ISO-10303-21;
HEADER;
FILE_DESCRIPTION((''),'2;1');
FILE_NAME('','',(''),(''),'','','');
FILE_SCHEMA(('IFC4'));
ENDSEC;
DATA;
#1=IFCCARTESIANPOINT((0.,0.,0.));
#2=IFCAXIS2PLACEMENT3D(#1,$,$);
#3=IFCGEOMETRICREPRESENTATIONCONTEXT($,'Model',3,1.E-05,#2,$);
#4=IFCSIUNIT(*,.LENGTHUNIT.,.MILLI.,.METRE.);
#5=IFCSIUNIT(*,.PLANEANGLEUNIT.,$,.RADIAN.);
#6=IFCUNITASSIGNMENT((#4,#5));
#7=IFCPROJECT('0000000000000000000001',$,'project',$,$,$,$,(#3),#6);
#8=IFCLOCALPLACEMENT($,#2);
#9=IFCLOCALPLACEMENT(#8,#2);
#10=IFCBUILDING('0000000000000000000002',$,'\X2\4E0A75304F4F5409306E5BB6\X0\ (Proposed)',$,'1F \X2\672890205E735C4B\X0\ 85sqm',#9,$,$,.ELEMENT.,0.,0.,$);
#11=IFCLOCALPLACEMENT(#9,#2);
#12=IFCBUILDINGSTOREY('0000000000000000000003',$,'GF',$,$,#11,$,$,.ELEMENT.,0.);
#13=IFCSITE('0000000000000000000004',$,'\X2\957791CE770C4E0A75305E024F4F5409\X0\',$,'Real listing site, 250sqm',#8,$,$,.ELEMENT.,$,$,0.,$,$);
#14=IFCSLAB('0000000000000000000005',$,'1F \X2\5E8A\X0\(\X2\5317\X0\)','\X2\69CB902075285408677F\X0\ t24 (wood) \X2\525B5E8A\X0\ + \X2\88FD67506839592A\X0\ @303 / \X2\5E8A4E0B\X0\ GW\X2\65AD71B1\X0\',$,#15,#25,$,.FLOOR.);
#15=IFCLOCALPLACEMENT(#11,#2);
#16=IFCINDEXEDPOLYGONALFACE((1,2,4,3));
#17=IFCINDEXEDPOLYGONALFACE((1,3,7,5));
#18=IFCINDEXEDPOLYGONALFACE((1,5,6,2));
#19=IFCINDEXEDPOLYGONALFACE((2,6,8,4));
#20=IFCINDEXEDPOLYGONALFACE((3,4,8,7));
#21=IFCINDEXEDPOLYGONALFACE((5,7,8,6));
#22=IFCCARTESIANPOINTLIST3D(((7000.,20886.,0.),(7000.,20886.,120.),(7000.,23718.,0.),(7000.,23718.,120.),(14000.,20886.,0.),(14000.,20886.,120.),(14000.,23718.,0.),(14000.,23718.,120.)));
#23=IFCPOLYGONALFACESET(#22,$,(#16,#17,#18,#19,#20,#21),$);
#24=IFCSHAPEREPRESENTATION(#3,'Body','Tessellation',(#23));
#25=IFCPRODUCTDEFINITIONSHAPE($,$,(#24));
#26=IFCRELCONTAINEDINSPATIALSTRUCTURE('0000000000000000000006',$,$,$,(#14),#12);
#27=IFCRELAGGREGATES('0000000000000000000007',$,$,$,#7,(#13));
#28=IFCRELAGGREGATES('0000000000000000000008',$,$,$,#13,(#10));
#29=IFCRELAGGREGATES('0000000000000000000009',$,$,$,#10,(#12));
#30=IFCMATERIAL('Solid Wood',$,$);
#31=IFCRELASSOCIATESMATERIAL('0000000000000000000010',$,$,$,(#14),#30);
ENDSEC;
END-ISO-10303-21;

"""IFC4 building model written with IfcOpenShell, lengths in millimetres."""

from ifc_helpers import new_model, si_unit, frame, frame_2d, origin, place, context, project, spatial, rectangle, extrude, material, element, save


model = new_model("IFC4")

# Units and contexts
model_context = context("Model", 3, precision=1e-05, world=origin())
ifc_project = project(units=[si_unit("LENGTHUNIT", "METRE", prefix="MILLI"), si_unit("PLANEANGLEUNIT", "RADIAN")], contexts=[model_context])

# Site, building, storey
site_placement = place(None, origin())
site = spatial("IfcSite", under=ifc_project, at=site_placement, Name="長野県上田市住吉", ObjectType="Real listing site, 250sqm", CompositionType="ELEMENT", RefElevation=0.0)
building_placement = place(site_placement, origin())
building = spatial("IfcBuilding", under=site, at=building_placement, Name="上田住吉の家 (Proposed)", ObjectType="1F 木造平屋 85sqm", CompositionType="ELEMENT", ElevationOfRefHeight=0.0, ElevationOfTerrain=0.0)
storey_placement = place(building_placement, origin())
storey = spatial("IfcBuildingStorey", under=building, at=storey_placement, Name="GF", CompositionType="ELEMENT", Elevation=0.0)

# Slab
ifc_material_1 = material(Name="Solid Wood")
slab_1_placement = place(storey_placement, frame((3500.0, 10443.0, 0.0)))
element("IfcSlab", 1, at=slab_1_placement, inside=storey, material=ifc_material_1, Name="1F 床(北)", Description="構造用合板 t24 (wood) 剛床 + 製材根太 @303 / 床下 GW断熱", PredefinedType="FLOOR", context=model_context, shape_type="SweptSolid", body=[
    extrude(rectangle(XDim=7000.0, YDim=2832.0, at=frame_2d((3500.0, 1416.0))), frame((3500.0, 10443.0, 0.0)), (0.0, 0.0, 1.0), 120.0),
])

save(model, "model.ifc")
